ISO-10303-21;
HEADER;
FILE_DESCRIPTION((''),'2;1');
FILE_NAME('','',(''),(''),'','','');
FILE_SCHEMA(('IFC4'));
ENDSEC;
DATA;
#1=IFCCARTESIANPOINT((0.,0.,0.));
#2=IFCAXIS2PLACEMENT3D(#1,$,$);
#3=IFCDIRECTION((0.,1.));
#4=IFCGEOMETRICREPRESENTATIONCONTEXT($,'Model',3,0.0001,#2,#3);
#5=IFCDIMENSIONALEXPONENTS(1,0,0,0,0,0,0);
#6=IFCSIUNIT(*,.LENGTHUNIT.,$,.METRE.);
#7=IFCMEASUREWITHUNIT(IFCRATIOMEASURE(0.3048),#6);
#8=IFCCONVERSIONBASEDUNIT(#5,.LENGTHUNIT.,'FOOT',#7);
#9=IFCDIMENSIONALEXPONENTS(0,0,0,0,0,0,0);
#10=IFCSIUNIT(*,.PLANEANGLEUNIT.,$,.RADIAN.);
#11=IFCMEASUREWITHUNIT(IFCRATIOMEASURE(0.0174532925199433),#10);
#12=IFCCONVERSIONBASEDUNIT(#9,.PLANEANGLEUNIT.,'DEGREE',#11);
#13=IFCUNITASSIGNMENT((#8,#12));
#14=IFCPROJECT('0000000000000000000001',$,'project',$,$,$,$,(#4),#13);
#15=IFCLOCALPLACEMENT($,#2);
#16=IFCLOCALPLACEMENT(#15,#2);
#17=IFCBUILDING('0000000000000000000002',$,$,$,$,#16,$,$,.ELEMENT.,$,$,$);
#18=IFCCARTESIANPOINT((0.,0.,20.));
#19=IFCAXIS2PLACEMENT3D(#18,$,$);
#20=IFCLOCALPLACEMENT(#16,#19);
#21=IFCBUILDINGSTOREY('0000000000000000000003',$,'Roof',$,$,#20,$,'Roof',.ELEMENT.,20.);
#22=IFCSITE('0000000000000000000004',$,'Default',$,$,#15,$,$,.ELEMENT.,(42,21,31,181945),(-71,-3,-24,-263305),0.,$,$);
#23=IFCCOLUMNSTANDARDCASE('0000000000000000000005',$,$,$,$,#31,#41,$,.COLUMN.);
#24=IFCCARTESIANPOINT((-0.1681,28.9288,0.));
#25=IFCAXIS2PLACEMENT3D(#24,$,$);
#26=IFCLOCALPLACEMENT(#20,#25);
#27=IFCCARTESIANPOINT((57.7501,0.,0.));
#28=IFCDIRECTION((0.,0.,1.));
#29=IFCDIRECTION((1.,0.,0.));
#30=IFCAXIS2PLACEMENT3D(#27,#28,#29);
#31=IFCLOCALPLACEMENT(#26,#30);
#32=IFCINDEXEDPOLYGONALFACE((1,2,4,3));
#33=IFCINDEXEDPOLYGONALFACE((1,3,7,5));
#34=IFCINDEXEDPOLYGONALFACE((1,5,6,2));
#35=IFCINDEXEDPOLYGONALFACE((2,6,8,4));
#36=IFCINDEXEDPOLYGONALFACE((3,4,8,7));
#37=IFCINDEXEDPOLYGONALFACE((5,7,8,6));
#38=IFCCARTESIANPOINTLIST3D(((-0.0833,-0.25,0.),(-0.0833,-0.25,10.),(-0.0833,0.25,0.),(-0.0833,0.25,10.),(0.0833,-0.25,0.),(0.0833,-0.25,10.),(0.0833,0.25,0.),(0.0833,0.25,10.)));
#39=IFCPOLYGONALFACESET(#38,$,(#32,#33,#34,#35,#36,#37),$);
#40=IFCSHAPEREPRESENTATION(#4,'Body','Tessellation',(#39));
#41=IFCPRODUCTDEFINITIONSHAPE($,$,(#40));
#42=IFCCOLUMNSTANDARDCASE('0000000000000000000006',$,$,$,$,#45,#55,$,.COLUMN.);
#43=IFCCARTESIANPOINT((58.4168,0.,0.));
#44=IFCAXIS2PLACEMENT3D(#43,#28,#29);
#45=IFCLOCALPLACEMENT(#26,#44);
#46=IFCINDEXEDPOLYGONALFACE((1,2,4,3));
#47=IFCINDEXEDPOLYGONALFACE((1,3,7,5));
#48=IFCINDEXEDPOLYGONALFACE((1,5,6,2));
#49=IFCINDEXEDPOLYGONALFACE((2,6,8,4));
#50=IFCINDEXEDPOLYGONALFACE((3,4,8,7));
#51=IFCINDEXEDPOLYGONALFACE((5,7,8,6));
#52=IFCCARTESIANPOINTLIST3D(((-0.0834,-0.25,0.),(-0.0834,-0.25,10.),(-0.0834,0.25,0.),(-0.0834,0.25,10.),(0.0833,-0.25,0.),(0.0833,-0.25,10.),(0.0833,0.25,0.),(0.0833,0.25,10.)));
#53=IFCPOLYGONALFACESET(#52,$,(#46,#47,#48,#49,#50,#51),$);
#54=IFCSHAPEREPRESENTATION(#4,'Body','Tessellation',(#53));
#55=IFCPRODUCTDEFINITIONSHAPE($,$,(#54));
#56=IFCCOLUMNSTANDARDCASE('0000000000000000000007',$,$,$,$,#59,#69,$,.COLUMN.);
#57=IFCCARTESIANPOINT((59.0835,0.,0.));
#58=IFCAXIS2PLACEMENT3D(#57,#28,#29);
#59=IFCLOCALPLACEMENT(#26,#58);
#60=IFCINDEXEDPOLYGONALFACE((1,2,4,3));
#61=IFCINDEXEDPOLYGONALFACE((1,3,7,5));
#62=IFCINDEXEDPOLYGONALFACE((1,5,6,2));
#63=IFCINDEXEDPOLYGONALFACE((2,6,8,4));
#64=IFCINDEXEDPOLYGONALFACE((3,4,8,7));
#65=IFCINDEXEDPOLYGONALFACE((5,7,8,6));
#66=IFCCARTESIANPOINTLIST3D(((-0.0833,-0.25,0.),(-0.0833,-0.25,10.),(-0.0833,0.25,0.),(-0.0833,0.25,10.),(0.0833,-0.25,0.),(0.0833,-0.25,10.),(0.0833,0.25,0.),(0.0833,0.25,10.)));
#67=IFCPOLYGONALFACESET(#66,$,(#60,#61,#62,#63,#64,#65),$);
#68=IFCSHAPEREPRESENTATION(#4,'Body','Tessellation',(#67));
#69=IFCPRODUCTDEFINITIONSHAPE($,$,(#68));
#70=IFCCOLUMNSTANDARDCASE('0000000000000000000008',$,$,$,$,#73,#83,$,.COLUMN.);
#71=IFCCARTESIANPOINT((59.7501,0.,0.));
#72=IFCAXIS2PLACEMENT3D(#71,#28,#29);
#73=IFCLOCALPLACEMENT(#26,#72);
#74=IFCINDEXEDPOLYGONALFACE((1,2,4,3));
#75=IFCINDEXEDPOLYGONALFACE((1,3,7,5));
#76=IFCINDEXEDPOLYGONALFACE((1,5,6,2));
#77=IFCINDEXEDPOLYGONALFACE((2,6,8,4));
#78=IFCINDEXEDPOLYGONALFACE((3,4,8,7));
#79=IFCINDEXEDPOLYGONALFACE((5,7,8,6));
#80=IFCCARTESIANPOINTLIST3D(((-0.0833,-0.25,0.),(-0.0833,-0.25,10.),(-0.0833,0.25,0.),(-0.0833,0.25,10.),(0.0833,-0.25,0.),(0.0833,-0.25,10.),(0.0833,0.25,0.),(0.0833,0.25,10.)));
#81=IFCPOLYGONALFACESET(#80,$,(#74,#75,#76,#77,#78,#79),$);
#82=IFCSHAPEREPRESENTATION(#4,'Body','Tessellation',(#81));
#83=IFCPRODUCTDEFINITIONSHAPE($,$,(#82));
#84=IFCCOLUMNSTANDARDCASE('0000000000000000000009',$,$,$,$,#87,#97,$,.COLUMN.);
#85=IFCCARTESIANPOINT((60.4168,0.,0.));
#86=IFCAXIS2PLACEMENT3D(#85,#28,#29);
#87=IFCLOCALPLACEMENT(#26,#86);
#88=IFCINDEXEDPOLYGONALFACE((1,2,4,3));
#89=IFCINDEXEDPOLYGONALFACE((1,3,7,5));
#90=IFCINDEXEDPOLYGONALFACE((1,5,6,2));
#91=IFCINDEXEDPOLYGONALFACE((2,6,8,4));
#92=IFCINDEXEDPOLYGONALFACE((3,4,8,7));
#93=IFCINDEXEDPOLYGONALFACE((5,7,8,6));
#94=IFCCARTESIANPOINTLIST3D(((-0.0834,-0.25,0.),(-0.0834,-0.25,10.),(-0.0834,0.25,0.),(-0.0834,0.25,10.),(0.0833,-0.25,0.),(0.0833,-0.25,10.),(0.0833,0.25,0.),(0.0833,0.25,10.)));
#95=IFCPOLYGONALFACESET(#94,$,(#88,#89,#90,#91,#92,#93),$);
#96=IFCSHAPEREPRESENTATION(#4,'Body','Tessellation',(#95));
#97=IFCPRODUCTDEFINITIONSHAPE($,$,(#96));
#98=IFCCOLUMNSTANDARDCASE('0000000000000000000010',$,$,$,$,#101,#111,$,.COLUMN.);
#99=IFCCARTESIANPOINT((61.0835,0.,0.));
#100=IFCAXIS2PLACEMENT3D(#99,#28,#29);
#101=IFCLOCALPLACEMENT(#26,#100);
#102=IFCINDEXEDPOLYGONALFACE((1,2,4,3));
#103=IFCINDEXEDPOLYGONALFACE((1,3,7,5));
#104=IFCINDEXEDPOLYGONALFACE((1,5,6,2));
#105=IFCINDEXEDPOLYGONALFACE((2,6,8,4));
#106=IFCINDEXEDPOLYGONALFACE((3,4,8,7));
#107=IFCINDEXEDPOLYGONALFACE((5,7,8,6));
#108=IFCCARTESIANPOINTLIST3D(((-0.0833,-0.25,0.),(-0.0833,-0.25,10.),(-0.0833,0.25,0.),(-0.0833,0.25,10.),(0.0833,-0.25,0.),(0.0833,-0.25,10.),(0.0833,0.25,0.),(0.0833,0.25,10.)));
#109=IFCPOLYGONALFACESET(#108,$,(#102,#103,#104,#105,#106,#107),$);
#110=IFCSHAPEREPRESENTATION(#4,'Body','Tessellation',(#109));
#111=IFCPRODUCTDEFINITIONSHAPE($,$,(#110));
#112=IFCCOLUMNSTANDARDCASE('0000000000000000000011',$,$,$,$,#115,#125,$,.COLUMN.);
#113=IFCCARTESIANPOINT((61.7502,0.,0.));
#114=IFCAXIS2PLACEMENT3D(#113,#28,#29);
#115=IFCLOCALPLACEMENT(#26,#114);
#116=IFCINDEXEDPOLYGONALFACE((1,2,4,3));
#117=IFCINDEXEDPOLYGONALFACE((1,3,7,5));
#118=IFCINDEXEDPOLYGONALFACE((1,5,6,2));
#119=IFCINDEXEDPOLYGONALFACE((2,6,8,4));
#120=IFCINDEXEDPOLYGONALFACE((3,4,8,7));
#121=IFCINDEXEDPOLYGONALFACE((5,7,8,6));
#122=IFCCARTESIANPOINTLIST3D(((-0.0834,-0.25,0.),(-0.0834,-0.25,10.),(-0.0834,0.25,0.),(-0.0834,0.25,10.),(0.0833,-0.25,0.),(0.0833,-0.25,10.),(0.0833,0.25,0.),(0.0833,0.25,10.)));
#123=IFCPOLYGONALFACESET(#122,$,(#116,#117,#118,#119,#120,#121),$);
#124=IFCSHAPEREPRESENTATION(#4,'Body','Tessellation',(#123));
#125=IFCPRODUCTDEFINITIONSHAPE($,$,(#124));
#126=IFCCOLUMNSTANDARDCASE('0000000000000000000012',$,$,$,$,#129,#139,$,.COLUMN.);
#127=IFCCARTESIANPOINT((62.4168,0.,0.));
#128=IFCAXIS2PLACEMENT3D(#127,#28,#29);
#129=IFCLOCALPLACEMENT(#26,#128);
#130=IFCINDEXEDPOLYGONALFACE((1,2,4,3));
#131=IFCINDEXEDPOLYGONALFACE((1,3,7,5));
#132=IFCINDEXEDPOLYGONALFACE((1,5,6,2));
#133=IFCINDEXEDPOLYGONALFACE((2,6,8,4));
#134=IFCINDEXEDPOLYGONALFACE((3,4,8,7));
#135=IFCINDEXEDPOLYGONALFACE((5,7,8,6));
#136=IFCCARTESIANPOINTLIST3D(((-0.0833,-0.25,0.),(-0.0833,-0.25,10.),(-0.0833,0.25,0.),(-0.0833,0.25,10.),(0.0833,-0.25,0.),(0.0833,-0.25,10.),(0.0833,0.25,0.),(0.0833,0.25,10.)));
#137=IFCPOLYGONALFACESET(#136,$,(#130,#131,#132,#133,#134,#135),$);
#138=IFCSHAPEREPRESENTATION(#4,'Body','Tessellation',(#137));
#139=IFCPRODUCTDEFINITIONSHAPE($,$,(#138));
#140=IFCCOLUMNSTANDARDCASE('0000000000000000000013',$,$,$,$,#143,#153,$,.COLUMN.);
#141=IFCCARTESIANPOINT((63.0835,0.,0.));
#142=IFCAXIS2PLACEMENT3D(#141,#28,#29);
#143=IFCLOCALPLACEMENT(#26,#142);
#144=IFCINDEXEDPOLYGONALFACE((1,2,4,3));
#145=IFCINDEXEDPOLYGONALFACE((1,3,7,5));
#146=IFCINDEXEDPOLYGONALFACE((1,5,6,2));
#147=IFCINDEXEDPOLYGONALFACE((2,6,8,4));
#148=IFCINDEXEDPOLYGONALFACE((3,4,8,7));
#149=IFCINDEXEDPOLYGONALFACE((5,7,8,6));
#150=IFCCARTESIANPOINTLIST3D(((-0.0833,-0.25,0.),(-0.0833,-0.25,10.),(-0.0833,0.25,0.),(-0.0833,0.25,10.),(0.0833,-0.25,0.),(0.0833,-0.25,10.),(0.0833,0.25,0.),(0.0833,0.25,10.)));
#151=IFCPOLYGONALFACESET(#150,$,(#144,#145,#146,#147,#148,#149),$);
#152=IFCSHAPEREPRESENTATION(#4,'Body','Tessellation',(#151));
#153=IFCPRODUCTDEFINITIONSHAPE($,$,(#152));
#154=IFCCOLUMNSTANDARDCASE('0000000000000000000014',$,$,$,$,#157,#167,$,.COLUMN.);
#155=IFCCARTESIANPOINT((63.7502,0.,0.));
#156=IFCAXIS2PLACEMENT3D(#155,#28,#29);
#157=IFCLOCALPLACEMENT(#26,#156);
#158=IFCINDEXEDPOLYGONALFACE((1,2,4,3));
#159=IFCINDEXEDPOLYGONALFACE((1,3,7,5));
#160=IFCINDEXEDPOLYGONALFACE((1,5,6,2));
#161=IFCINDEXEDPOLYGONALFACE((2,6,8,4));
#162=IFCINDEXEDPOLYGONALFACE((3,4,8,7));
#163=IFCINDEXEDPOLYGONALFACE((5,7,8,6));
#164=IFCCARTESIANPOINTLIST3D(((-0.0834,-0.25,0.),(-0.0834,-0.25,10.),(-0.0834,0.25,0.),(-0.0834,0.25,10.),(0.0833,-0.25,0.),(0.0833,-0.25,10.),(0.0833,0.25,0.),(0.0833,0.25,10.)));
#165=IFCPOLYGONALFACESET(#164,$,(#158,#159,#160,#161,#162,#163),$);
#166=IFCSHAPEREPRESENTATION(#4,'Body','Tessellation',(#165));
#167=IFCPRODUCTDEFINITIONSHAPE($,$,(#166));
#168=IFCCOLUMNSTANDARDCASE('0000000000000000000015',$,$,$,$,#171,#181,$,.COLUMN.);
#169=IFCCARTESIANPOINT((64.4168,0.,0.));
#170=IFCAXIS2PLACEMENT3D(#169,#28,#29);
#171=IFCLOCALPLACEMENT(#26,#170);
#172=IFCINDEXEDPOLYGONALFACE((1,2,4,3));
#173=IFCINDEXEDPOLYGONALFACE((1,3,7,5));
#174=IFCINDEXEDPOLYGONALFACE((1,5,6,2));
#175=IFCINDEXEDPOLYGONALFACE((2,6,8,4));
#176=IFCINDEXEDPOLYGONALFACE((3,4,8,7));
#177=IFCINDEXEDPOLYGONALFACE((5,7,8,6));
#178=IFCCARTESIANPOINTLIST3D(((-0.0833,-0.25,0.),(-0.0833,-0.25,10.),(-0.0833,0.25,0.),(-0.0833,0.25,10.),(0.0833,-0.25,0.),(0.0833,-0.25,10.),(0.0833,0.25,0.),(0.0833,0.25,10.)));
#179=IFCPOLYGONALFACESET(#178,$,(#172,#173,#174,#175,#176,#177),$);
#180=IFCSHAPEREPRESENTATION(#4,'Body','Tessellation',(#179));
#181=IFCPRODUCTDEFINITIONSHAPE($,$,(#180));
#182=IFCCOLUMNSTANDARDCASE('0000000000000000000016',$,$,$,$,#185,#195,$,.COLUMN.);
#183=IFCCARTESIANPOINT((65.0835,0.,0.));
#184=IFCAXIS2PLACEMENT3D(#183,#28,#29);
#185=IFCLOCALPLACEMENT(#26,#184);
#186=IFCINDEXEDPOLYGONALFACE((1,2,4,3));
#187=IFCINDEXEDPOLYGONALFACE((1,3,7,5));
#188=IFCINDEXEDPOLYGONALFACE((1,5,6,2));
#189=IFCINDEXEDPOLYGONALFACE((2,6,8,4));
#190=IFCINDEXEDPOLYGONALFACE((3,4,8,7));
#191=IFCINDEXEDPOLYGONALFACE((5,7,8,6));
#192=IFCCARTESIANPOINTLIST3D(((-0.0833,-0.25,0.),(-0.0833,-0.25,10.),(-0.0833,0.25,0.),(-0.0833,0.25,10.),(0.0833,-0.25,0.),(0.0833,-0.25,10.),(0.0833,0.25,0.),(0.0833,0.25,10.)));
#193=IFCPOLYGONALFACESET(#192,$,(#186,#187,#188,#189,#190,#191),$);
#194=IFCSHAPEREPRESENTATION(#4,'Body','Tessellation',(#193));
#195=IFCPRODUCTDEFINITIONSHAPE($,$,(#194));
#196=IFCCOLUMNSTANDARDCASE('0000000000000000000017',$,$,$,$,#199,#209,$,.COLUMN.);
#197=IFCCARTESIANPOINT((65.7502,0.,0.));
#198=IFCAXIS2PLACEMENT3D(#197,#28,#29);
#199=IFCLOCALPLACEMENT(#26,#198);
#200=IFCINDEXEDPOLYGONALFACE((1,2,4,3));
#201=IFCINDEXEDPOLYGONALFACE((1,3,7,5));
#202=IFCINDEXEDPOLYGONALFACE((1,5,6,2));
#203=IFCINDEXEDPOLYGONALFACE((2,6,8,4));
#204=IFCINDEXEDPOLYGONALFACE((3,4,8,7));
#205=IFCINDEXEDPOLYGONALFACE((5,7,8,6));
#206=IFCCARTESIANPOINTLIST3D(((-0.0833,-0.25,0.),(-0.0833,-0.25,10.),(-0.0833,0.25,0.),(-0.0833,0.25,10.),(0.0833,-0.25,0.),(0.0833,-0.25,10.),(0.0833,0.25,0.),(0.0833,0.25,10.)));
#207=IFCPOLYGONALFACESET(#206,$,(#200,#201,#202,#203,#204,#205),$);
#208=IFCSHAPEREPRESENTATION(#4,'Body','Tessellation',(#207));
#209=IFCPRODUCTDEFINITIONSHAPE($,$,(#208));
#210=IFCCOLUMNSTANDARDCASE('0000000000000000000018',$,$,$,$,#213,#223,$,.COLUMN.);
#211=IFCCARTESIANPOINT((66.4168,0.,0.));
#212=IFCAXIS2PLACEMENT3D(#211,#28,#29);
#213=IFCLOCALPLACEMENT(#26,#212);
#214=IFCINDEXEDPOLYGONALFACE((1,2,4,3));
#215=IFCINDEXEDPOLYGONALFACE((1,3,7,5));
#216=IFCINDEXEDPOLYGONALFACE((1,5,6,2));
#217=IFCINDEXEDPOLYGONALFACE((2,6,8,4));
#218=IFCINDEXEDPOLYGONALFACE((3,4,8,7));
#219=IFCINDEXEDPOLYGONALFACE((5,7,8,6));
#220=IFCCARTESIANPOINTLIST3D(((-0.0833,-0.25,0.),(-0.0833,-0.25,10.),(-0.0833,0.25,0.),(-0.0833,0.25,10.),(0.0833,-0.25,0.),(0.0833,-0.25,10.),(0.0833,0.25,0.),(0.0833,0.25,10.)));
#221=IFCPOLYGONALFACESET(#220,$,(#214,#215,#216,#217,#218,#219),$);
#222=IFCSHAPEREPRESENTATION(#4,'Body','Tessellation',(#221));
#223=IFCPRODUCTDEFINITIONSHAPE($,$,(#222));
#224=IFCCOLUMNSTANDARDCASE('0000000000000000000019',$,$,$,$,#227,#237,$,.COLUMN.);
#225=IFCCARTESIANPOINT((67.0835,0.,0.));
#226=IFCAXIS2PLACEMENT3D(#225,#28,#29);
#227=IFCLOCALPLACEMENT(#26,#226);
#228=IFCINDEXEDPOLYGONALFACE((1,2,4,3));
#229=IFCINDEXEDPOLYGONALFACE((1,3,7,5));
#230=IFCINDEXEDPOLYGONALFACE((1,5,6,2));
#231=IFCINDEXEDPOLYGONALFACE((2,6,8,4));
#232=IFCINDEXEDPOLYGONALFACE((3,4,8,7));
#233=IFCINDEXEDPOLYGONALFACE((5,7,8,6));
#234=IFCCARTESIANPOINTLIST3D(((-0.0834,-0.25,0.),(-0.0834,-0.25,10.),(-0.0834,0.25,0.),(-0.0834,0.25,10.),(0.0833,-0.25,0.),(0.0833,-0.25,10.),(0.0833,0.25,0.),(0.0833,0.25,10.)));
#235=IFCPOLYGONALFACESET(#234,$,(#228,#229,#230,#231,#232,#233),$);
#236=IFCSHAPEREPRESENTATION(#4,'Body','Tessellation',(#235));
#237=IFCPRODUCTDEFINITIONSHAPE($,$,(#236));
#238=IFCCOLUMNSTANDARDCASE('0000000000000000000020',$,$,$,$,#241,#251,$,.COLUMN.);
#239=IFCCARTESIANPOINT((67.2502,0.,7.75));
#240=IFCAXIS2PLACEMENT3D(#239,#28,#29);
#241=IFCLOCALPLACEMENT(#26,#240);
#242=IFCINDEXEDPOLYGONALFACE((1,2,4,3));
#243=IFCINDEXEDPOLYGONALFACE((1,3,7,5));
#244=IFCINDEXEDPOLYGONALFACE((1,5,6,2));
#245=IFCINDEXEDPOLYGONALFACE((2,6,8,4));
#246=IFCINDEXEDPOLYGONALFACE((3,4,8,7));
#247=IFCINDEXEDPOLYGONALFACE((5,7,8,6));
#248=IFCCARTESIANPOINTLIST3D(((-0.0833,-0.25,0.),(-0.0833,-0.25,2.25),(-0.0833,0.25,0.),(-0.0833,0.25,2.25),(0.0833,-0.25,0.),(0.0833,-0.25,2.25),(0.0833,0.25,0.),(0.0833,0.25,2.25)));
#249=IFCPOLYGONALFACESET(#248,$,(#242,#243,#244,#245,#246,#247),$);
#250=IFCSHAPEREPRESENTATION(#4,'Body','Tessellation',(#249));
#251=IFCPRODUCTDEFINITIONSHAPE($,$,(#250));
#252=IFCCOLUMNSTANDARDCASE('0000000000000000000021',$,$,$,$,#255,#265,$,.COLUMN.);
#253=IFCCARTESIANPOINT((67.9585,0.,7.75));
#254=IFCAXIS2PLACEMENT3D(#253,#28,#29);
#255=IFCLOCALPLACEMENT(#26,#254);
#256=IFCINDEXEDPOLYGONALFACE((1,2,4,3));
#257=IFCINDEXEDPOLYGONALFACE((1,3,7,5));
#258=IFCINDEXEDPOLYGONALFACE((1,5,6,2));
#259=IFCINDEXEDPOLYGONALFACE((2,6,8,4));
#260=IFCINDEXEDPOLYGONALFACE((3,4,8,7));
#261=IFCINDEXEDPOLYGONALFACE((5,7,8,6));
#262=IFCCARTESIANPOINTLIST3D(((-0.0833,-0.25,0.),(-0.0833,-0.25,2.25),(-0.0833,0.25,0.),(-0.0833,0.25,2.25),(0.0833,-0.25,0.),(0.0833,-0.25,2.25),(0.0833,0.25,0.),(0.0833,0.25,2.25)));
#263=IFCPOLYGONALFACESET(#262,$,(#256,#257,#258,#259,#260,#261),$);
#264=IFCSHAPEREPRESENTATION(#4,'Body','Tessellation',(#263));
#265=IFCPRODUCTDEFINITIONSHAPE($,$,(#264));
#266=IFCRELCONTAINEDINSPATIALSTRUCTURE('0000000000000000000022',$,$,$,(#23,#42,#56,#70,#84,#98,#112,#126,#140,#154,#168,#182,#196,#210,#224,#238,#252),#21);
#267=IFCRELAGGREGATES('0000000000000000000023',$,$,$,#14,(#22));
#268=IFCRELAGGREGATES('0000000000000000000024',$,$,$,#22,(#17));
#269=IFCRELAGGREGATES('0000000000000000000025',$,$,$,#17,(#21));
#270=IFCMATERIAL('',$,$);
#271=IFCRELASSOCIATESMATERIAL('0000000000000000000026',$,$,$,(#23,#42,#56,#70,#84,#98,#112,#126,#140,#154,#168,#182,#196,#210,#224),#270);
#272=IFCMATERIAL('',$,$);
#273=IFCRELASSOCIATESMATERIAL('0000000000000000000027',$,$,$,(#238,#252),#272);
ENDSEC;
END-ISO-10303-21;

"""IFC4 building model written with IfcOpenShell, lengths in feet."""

from ifc_helpers import new_model, entity, si_unit, converted_unit, direction, frame, origin, place, context, project, spatial, rectangle, extrude, material, element, save


model = new_model("IFC4")

# Units and contexts
model_context = context("Model", 3, precision=0.0001, world=origin(), true_north=direction((0.0, 1.0)))
ifc_project = project(units=[converted_unit("LENGTHUNIT", "FOOT", entity("IfcRatioMeasure", 0.3048), si_unit("LENGTHUNIT", "METRE"), dimensions=[1, 0, 0, 0, 0, 0, 0]), converted_unit("PLANEANGLEUNIT", "DEGREE", entity("IfcRatioMeasure", 0.0174532925199433), si_unit("PLANEANGLEUNIT", "RADIAN"), dimensions=[0, 0, 0, 0, 0, 0, 0])], contexts=[model_context])

# Site, building, storey
site_placement = place(None, origin())
site = spatial("IfcSite", under=ifc_project, at=site_placement, Name="Default", CompositionType="ELEMENT", RefLatitude=(42, 21, 31, 181945), RefLongitude=(-71, -3, -24, -263305), RefElevation=0.0)
building_placement = place(site_placement, origin())
building = spatial("IfcBuilding", under=site, at=building_placement, CompositionType="ELEMENT")
storey_placement = place(building_placement, frame((0.0, 0.0, 20.0)))
storey = spatial("IfcBuildingStorey", under=building, at=storey_placement, Name="Roof", LongName="Roof", CompositionType="ELEMENT", Elevation=20.0)

# Columns
ifc_material_1 = material(Name="")
placement = place(storey_placement, frame((-0.1681, 28.9288, 0.0)))
for number, where, z_axis, x_axis in (
    (1, (57.7501, 0.0, 0.0), (0.0, 0.0, 1.0), (1.0, 0.0, 0.0)),
    (2, (58.4168, 0.0, 0.0), (0.0, 0.0, 1.0), (1.0, 0.0, 0.0)),
    (3, (59.0835, 0.0, 0.0), (0.0, 0.0, 1.0), (1.0, 0.0, 0.0)),
    (4, (59.7501, 0.0, 0.0), (0.0, 0.0, 1.0), (1.0, 0.0, 0.0)),
    (5, (60.4168, 0.0, 0.0), (0.0, 0.0, 1.0), (1.0, 0.0, 0.0)),
    (6, (61.0835, 0.0, 0.0), (0.0, 0.0, 1.0), (1.0, 0.0, 0.0)),
    (7, (61.7502, 0.0, 0.0), (0.0, 0.0, 1.0), (1.0, 0.0, 0.0)),
    (8, (62.4168, 0.0, 0.0), (0.0, 0.0, 1.0), (1.0, 0.0, 0.0)),
    (9, (63.0835, 0.0, 0.0), (0.0, 0.0, 1.0), (1.0, 0.0, 0.0)),
    (10, (63.7502, 0.0, 0.0), (0.0, 0.0, 1.0), (1.0, 0.0, 0.0)),
    (11, (64.4168, 0.0, 0.0), (0.0, 0.0, 1.0), (1.0, 0.0, 0.0)),
    (12, (65.0835, 0.0, 0.0), (0.0, 0.0, 1.0), (1.0, 0.0, 0.0)),
    (13, (65.7502, 0.0, 0.0), (0.0, 0.0, 1.0), (1.0, 0.0, 0.0)),
    (14, (66.4168, 0.0, 0.0), (0.0, 0.0, 1.0), (1.0, 0.0, 0.0)),
    (15, (67.0835, 0.0, 0.0), (0.0, 0.0, 1.0), (1.0, 0.0, 0.0)),
):
    element("IfcColumnStandardCase", number, at=place(placement, frame(where, z_axis=z_axis, x_axis=x_axis)), inside=storey, material=ifc_material_1, PredefinedType="COLUMN", context=model_context, shape_type="SweptSolid", body=[
        extrude(rectangle(XDim=0.1667, YDim=0.5), origin(), (0.0, 0.0, 1.0), 10.0),
    ])
ifc_material_2 = material(Name="")
for number, where, z_axis, x_axis in (
    (16, (67.2502, 0.0, 7.75), (0.0, 0.0, 1.0), (1.0, 0.0, 0.0)),
    (17, (67.9585, 0.0, 7.75), (0.0, 0.0, 1.0), (1.0, 0.0, 0.0)),
):
    element("IfcColumnStandardCase", number, at=place(placement, frame(where, z_axis=z_axis, x_axis=x_axis)), inside=storey, material=ifc_material_2, PredefinedType="COLUMN", context=model_context, shape_type="SweptSolid", body=[
        extrude(rectangle(XDim=0.1667, YDim=0.5), origin(), (0.0, 0.0, 1.0), 2.25),
    ])

save(model, "model.ifc")
